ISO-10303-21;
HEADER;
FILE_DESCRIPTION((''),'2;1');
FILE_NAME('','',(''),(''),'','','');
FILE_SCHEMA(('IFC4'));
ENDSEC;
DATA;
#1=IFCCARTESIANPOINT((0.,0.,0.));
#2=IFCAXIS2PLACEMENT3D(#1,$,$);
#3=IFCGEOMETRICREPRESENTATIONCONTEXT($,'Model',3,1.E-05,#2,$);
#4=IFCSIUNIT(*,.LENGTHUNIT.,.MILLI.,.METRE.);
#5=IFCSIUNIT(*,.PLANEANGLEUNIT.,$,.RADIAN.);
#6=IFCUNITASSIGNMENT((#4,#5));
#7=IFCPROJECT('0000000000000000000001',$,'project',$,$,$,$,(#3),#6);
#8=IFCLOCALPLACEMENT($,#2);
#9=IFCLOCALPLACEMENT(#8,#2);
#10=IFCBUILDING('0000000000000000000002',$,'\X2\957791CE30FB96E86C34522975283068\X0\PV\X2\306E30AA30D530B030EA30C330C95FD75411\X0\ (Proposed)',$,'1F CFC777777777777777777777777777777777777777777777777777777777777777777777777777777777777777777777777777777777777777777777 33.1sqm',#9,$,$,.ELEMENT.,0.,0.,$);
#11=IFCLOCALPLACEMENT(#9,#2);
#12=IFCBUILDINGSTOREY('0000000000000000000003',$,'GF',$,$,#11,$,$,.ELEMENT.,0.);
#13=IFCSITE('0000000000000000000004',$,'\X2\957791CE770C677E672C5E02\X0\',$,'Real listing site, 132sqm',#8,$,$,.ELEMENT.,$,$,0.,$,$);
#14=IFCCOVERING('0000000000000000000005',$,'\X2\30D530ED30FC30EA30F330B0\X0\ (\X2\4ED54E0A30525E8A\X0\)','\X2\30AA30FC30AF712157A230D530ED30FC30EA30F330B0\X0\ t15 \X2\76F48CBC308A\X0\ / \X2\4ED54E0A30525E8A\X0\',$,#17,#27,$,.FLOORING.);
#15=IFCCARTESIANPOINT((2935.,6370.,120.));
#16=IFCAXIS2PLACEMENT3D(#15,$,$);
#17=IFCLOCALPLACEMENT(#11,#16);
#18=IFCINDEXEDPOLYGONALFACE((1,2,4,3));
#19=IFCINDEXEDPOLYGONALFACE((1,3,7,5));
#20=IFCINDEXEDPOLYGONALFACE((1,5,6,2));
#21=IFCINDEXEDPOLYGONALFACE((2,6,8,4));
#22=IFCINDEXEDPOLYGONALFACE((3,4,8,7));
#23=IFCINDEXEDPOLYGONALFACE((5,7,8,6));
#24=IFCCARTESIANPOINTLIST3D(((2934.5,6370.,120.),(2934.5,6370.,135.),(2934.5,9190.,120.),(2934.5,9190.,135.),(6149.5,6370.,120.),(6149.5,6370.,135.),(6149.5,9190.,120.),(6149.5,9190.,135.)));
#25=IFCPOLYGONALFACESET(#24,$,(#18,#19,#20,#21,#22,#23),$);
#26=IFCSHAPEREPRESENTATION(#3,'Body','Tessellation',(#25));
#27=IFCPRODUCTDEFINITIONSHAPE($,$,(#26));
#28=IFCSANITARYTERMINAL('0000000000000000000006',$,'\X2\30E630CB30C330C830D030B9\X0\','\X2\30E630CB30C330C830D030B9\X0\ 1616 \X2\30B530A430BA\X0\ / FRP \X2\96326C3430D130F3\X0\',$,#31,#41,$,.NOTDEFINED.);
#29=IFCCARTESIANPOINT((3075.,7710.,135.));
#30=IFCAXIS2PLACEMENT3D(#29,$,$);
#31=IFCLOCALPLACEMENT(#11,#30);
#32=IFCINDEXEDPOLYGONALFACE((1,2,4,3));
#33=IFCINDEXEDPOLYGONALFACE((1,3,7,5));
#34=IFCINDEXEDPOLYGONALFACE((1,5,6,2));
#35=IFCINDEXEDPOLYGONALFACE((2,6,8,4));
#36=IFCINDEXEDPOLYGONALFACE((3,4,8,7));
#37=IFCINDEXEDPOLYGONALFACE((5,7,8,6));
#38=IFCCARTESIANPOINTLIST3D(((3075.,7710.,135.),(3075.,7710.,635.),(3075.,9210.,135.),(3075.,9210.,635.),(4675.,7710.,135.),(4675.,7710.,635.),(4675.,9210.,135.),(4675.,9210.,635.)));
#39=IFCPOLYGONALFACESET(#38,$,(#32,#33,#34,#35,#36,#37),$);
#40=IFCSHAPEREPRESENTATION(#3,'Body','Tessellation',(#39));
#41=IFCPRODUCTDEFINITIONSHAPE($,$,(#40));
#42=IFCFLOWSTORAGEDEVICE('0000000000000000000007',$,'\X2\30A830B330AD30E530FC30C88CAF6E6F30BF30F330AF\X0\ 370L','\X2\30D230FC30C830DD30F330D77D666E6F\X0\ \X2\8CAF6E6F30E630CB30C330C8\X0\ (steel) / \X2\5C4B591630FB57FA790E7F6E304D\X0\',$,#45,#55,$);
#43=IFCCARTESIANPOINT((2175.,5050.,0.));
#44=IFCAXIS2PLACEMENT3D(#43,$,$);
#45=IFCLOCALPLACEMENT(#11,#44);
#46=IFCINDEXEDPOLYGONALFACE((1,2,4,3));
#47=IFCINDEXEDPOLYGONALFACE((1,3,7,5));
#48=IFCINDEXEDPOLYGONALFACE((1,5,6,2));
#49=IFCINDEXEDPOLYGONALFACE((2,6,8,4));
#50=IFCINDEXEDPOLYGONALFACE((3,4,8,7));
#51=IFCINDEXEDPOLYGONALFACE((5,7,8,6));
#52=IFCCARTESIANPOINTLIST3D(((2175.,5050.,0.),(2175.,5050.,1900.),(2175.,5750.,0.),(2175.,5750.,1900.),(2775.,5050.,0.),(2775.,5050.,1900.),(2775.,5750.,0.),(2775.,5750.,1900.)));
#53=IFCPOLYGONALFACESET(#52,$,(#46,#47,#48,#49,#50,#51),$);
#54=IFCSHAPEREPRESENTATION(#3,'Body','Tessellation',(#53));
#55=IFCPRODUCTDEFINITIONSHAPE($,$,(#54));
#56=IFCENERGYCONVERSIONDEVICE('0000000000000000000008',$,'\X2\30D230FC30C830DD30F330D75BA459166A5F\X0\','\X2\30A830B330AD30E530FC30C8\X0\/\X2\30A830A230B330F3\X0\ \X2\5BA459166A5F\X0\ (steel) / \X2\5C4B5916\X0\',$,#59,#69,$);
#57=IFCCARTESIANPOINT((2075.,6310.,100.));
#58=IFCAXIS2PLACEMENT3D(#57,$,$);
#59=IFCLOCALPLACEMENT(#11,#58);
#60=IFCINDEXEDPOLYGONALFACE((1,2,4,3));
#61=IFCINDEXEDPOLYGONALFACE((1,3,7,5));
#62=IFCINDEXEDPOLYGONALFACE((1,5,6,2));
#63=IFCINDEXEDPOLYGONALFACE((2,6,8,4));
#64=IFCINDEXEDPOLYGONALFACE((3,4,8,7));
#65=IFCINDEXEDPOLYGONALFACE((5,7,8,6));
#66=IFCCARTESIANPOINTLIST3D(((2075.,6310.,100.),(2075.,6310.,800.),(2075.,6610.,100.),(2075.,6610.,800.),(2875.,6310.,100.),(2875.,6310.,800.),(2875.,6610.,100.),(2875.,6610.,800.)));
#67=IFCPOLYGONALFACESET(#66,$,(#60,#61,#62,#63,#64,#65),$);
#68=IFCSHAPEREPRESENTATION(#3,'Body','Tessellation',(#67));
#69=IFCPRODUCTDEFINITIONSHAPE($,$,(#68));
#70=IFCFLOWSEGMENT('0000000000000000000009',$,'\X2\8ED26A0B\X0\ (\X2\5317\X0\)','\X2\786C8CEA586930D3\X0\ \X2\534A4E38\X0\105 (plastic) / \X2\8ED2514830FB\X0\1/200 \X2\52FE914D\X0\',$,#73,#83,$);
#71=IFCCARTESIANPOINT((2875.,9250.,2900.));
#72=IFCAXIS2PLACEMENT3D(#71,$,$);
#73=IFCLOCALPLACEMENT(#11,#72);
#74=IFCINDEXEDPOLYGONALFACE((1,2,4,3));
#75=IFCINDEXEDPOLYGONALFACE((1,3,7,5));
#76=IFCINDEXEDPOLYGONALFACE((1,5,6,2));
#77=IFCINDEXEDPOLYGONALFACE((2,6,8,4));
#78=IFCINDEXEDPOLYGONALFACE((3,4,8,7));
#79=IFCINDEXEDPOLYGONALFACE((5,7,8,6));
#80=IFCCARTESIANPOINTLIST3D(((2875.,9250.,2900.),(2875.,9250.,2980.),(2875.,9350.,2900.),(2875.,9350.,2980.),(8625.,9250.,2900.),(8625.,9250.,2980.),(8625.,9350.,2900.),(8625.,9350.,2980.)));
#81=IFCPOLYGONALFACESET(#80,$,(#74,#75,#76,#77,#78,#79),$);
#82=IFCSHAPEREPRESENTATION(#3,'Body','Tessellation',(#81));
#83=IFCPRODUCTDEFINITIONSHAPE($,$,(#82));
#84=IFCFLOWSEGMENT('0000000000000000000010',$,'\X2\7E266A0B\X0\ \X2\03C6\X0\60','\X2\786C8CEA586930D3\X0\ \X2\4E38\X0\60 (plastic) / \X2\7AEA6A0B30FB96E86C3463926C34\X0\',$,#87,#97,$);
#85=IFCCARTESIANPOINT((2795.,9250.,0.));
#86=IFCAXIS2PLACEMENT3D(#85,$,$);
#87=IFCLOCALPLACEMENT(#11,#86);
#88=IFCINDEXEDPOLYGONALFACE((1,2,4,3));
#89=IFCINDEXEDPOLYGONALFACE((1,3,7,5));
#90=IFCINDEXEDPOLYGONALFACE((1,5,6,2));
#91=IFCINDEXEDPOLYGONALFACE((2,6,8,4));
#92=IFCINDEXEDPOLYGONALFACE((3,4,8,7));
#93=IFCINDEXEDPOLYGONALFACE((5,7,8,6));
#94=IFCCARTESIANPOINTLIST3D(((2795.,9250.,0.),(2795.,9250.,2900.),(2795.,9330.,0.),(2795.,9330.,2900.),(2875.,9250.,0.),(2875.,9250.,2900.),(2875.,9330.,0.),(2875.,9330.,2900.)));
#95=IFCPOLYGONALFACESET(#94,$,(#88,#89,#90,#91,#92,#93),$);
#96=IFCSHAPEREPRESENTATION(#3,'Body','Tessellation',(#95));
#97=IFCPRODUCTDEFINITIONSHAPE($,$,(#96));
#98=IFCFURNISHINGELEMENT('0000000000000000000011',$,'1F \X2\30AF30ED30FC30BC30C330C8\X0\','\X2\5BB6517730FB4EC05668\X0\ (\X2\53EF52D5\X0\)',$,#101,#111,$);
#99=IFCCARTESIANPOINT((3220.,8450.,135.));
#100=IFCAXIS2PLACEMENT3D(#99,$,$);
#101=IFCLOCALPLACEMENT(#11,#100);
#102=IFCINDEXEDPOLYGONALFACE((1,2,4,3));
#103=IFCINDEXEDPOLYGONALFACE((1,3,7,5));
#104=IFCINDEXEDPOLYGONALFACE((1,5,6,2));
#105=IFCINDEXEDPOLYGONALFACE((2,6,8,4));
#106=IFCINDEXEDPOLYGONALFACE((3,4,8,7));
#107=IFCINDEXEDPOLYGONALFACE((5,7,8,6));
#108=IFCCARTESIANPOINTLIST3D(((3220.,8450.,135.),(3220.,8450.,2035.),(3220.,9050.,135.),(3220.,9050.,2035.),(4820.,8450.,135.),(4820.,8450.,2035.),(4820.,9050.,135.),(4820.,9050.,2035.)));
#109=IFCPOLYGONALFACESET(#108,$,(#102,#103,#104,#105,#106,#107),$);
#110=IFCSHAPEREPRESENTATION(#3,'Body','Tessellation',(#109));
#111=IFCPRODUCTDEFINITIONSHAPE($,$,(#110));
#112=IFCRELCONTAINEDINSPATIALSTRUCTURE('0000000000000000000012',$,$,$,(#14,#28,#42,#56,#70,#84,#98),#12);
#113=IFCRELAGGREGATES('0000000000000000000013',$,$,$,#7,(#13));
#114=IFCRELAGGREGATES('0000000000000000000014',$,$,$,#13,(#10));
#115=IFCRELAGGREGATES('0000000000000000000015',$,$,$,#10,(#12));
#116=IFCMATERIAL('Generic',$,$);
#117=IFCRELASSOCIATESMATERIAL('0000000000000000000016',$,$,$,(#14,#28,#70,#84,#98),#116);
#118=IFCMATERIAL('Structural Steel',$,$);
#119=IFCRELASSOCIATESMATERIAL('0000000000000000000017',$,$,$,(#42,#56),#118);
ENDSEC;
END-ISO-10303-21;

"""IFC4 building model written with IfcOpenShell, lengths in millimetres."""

from ifc_helpers import new_model, si_unit, frame, frame_2d, origin, place, context, project, spatial, rectangle, extrude, material, element, save


model = new_model("IFC4")

# Units and contexts
model_context = context("Model", 3, precision=1e-05, world=origin())
ifc_project = project(units=[si_unit("LENGTHUNIT", "METRE", prefix="MILLI"), si_unit("PLANEANGLEUNIT", "RADIAN")], contexts=[model_context])

# Site, building, storey
site_placement = place(None, origin())
site = spatial("IfcSite", under=ifc_project, at=site_placement, Name="長野県松本市", ObjectType="Real listing site, 132sqm", CompositionType="ELEMENT", RefElevation=0.0)
building_placement = place(site_placement, origin())
building = spatial("IfcBuilding", under=site, at=building_placement, Name="長野・雨水利用とPVのオフグリッド志向 (Proposed)", ObjectType="1F CFC777777777777777777777777777777777777777777777777777777777777777777777777777777777777777777777777777777777777777777777 33.1sqm", CompositionType="ELEMENT", ElevationOfRefHeight=0.0, ElevationOfTerrain=0.0)
storey_placement = place(building_placement, origin())
storey = spatial("IfcBuildingStorey", under=building, at=storey_placement, Name="GF", CompositionType="ELEMENT", Elevation=0.0)

# Shared definitions
ifc_material_1 = material(Name="Structural Steel")

# Covering
ifc_material_2 = material(Name="Generic")
covering_placement = place(storey_placement, frame((2935.0, 6370.0, 120.0)))
element("IfcCovering", 1, at=covering_placement, inside=storey, material=ifc_material_2, Name="フローリング (仕上げ床)", Description="オーク無垢フローリング t15 直貼り / 仕上げ床", PredefinedType="FLOORING", context=model_context, shape_type="SweptSolid", body=[
    extrude(rectangle(XDim=3215.0, YDim=2820.0, at=frame_2d((1607.0, 1410.0))), frame((2935.0, 6370.0, 120.0)), (0.0, 0.0, 1.0), 15.0),
])

# Sanitary terminal
sanitary_terminal_placement = place(storey_placement, frame((3075.0, 7710.0, 135.0)))
element("IfcSanitaryTerminal", 2, at=sanitary_terminal_placement, inside=storey, material=ifc_material_2, Name="ユニットバス", Description="ユニットバス 1616 サイズ / FRP 防水パン", PredefinedType="NOTDEFINED", context=model_context, shape_type="SweptSolid", body=[
    extrude(rectangle(XDim=1600.0, YDim=1500.0, at=frame_2d((800.0, 750.0))), frame((3075.0, 7710.0, 135.0)), (0.0, 0.0, 1.0), 500.0),
])

# Flow storage device
flow_storage_device_placement = place(storey_placement, frame((2175.0, 5050.0, 0.0)))
element("IfcFlowStorageDevice", 3, at=flow_storage_device_placement, inside=storey, material=ifc_material_1, Name="エコキュート貯湯タンク 370L", Description="ヒートポンプ給湯 貯湯ユニット (steel) / 屋外・基礎置き", context=model_context, shape_type="SweptSolid", body=[
    extrude(rectangle(XDim=600.0, YDim=700.0, at=frame_2d((300.0, 350.0))), frame((2175.0, 5050.0, 0.0)), (0.0, 0.0, 1.0), 1900.0),
])

# Energy conversion device
energy_conversion_device_placement = place(storey_placement, frame((2075.0, 6310.0, 100.0)))
element("IfcEnergyConversionDevice", 4, at=energy_conversion_device_placement, inside=storey, material=ifc_material_1, Name="ヒートポンプ室外機", Description="エコキュート/エアコン 室外機 (steel) / 屋外", context=model_context, shape_type="SweptSolid", body=[
    extrude(rectangle(XDim=800.0, YDim=300.0, at=frame_2d((400.0, 150.0))), frame((2075.0, 6310.0, 100.0)), (0.0, 0.0, 1.0), 700.0),
])

# Flow segments
flow_segment_1_placement = place(storey_placement, frame((2875.0, 9250.0, 2900.0)))
element("IfcFlowSegment", 5, at=flow_segment_1_placement, inside=storey, material=ifc_material_2, Name="軒樋 (北)", Description="硬質塩ビ 半丸105 (plastic) / 軒先・1/200 勾配", context=model_context, shape_type="SweptSolid", body=[
    extrude(rectangle(XDim=5750.0, YDim=100.0, at=frame_2d((2875.0, 50.0))), frame((2875.0, 9250.0, 2900.0)), (0.0, 0.0, 1.0), 80.0),
])
flow_segment_2_placement = place(storey_placement, frame((2795.0, 9250.0, 0.0)))
element("IfcFlowSegment", 6, at=flow_segment_2_placement, inside=storey, material=ifc_material_2, Name="縦樋 φ60", Description="硬質塩ビ 丸60 (plastic) / 竪樋・雨水排水", context=model_context, shape_type="SweptSolid", body=[
    extrude(rectangle(XDim=80.0, YDim=80.0, at=frame_2d((40.0, 40.0))), frame((2795.0, 9250.0, 0.0)), (0.0, 0.0, 1.0), 2900.0),
])

# Furnishing element
furnishing_placement = place(storey_placement, frame((3220.0, 8450.0, 135.0)))
element("IfcFurnishingElement", 7, at=furnishing_placement, inside=storey, material=ifc_material_2, Name="1F クローゼット", Description="家具・什器 (可動)", context=model_context, shape_type="SweptSolid", body=[
    extrude(rectangle(XDim=1600.0, YDim=600.0, at=frame_2d((800.0, 300.0))), frame((3220.0, 8450.0, 135.0)), (0.0, 0.0, 1.0), 1900.0),
])

save(model, "model.ifc")
